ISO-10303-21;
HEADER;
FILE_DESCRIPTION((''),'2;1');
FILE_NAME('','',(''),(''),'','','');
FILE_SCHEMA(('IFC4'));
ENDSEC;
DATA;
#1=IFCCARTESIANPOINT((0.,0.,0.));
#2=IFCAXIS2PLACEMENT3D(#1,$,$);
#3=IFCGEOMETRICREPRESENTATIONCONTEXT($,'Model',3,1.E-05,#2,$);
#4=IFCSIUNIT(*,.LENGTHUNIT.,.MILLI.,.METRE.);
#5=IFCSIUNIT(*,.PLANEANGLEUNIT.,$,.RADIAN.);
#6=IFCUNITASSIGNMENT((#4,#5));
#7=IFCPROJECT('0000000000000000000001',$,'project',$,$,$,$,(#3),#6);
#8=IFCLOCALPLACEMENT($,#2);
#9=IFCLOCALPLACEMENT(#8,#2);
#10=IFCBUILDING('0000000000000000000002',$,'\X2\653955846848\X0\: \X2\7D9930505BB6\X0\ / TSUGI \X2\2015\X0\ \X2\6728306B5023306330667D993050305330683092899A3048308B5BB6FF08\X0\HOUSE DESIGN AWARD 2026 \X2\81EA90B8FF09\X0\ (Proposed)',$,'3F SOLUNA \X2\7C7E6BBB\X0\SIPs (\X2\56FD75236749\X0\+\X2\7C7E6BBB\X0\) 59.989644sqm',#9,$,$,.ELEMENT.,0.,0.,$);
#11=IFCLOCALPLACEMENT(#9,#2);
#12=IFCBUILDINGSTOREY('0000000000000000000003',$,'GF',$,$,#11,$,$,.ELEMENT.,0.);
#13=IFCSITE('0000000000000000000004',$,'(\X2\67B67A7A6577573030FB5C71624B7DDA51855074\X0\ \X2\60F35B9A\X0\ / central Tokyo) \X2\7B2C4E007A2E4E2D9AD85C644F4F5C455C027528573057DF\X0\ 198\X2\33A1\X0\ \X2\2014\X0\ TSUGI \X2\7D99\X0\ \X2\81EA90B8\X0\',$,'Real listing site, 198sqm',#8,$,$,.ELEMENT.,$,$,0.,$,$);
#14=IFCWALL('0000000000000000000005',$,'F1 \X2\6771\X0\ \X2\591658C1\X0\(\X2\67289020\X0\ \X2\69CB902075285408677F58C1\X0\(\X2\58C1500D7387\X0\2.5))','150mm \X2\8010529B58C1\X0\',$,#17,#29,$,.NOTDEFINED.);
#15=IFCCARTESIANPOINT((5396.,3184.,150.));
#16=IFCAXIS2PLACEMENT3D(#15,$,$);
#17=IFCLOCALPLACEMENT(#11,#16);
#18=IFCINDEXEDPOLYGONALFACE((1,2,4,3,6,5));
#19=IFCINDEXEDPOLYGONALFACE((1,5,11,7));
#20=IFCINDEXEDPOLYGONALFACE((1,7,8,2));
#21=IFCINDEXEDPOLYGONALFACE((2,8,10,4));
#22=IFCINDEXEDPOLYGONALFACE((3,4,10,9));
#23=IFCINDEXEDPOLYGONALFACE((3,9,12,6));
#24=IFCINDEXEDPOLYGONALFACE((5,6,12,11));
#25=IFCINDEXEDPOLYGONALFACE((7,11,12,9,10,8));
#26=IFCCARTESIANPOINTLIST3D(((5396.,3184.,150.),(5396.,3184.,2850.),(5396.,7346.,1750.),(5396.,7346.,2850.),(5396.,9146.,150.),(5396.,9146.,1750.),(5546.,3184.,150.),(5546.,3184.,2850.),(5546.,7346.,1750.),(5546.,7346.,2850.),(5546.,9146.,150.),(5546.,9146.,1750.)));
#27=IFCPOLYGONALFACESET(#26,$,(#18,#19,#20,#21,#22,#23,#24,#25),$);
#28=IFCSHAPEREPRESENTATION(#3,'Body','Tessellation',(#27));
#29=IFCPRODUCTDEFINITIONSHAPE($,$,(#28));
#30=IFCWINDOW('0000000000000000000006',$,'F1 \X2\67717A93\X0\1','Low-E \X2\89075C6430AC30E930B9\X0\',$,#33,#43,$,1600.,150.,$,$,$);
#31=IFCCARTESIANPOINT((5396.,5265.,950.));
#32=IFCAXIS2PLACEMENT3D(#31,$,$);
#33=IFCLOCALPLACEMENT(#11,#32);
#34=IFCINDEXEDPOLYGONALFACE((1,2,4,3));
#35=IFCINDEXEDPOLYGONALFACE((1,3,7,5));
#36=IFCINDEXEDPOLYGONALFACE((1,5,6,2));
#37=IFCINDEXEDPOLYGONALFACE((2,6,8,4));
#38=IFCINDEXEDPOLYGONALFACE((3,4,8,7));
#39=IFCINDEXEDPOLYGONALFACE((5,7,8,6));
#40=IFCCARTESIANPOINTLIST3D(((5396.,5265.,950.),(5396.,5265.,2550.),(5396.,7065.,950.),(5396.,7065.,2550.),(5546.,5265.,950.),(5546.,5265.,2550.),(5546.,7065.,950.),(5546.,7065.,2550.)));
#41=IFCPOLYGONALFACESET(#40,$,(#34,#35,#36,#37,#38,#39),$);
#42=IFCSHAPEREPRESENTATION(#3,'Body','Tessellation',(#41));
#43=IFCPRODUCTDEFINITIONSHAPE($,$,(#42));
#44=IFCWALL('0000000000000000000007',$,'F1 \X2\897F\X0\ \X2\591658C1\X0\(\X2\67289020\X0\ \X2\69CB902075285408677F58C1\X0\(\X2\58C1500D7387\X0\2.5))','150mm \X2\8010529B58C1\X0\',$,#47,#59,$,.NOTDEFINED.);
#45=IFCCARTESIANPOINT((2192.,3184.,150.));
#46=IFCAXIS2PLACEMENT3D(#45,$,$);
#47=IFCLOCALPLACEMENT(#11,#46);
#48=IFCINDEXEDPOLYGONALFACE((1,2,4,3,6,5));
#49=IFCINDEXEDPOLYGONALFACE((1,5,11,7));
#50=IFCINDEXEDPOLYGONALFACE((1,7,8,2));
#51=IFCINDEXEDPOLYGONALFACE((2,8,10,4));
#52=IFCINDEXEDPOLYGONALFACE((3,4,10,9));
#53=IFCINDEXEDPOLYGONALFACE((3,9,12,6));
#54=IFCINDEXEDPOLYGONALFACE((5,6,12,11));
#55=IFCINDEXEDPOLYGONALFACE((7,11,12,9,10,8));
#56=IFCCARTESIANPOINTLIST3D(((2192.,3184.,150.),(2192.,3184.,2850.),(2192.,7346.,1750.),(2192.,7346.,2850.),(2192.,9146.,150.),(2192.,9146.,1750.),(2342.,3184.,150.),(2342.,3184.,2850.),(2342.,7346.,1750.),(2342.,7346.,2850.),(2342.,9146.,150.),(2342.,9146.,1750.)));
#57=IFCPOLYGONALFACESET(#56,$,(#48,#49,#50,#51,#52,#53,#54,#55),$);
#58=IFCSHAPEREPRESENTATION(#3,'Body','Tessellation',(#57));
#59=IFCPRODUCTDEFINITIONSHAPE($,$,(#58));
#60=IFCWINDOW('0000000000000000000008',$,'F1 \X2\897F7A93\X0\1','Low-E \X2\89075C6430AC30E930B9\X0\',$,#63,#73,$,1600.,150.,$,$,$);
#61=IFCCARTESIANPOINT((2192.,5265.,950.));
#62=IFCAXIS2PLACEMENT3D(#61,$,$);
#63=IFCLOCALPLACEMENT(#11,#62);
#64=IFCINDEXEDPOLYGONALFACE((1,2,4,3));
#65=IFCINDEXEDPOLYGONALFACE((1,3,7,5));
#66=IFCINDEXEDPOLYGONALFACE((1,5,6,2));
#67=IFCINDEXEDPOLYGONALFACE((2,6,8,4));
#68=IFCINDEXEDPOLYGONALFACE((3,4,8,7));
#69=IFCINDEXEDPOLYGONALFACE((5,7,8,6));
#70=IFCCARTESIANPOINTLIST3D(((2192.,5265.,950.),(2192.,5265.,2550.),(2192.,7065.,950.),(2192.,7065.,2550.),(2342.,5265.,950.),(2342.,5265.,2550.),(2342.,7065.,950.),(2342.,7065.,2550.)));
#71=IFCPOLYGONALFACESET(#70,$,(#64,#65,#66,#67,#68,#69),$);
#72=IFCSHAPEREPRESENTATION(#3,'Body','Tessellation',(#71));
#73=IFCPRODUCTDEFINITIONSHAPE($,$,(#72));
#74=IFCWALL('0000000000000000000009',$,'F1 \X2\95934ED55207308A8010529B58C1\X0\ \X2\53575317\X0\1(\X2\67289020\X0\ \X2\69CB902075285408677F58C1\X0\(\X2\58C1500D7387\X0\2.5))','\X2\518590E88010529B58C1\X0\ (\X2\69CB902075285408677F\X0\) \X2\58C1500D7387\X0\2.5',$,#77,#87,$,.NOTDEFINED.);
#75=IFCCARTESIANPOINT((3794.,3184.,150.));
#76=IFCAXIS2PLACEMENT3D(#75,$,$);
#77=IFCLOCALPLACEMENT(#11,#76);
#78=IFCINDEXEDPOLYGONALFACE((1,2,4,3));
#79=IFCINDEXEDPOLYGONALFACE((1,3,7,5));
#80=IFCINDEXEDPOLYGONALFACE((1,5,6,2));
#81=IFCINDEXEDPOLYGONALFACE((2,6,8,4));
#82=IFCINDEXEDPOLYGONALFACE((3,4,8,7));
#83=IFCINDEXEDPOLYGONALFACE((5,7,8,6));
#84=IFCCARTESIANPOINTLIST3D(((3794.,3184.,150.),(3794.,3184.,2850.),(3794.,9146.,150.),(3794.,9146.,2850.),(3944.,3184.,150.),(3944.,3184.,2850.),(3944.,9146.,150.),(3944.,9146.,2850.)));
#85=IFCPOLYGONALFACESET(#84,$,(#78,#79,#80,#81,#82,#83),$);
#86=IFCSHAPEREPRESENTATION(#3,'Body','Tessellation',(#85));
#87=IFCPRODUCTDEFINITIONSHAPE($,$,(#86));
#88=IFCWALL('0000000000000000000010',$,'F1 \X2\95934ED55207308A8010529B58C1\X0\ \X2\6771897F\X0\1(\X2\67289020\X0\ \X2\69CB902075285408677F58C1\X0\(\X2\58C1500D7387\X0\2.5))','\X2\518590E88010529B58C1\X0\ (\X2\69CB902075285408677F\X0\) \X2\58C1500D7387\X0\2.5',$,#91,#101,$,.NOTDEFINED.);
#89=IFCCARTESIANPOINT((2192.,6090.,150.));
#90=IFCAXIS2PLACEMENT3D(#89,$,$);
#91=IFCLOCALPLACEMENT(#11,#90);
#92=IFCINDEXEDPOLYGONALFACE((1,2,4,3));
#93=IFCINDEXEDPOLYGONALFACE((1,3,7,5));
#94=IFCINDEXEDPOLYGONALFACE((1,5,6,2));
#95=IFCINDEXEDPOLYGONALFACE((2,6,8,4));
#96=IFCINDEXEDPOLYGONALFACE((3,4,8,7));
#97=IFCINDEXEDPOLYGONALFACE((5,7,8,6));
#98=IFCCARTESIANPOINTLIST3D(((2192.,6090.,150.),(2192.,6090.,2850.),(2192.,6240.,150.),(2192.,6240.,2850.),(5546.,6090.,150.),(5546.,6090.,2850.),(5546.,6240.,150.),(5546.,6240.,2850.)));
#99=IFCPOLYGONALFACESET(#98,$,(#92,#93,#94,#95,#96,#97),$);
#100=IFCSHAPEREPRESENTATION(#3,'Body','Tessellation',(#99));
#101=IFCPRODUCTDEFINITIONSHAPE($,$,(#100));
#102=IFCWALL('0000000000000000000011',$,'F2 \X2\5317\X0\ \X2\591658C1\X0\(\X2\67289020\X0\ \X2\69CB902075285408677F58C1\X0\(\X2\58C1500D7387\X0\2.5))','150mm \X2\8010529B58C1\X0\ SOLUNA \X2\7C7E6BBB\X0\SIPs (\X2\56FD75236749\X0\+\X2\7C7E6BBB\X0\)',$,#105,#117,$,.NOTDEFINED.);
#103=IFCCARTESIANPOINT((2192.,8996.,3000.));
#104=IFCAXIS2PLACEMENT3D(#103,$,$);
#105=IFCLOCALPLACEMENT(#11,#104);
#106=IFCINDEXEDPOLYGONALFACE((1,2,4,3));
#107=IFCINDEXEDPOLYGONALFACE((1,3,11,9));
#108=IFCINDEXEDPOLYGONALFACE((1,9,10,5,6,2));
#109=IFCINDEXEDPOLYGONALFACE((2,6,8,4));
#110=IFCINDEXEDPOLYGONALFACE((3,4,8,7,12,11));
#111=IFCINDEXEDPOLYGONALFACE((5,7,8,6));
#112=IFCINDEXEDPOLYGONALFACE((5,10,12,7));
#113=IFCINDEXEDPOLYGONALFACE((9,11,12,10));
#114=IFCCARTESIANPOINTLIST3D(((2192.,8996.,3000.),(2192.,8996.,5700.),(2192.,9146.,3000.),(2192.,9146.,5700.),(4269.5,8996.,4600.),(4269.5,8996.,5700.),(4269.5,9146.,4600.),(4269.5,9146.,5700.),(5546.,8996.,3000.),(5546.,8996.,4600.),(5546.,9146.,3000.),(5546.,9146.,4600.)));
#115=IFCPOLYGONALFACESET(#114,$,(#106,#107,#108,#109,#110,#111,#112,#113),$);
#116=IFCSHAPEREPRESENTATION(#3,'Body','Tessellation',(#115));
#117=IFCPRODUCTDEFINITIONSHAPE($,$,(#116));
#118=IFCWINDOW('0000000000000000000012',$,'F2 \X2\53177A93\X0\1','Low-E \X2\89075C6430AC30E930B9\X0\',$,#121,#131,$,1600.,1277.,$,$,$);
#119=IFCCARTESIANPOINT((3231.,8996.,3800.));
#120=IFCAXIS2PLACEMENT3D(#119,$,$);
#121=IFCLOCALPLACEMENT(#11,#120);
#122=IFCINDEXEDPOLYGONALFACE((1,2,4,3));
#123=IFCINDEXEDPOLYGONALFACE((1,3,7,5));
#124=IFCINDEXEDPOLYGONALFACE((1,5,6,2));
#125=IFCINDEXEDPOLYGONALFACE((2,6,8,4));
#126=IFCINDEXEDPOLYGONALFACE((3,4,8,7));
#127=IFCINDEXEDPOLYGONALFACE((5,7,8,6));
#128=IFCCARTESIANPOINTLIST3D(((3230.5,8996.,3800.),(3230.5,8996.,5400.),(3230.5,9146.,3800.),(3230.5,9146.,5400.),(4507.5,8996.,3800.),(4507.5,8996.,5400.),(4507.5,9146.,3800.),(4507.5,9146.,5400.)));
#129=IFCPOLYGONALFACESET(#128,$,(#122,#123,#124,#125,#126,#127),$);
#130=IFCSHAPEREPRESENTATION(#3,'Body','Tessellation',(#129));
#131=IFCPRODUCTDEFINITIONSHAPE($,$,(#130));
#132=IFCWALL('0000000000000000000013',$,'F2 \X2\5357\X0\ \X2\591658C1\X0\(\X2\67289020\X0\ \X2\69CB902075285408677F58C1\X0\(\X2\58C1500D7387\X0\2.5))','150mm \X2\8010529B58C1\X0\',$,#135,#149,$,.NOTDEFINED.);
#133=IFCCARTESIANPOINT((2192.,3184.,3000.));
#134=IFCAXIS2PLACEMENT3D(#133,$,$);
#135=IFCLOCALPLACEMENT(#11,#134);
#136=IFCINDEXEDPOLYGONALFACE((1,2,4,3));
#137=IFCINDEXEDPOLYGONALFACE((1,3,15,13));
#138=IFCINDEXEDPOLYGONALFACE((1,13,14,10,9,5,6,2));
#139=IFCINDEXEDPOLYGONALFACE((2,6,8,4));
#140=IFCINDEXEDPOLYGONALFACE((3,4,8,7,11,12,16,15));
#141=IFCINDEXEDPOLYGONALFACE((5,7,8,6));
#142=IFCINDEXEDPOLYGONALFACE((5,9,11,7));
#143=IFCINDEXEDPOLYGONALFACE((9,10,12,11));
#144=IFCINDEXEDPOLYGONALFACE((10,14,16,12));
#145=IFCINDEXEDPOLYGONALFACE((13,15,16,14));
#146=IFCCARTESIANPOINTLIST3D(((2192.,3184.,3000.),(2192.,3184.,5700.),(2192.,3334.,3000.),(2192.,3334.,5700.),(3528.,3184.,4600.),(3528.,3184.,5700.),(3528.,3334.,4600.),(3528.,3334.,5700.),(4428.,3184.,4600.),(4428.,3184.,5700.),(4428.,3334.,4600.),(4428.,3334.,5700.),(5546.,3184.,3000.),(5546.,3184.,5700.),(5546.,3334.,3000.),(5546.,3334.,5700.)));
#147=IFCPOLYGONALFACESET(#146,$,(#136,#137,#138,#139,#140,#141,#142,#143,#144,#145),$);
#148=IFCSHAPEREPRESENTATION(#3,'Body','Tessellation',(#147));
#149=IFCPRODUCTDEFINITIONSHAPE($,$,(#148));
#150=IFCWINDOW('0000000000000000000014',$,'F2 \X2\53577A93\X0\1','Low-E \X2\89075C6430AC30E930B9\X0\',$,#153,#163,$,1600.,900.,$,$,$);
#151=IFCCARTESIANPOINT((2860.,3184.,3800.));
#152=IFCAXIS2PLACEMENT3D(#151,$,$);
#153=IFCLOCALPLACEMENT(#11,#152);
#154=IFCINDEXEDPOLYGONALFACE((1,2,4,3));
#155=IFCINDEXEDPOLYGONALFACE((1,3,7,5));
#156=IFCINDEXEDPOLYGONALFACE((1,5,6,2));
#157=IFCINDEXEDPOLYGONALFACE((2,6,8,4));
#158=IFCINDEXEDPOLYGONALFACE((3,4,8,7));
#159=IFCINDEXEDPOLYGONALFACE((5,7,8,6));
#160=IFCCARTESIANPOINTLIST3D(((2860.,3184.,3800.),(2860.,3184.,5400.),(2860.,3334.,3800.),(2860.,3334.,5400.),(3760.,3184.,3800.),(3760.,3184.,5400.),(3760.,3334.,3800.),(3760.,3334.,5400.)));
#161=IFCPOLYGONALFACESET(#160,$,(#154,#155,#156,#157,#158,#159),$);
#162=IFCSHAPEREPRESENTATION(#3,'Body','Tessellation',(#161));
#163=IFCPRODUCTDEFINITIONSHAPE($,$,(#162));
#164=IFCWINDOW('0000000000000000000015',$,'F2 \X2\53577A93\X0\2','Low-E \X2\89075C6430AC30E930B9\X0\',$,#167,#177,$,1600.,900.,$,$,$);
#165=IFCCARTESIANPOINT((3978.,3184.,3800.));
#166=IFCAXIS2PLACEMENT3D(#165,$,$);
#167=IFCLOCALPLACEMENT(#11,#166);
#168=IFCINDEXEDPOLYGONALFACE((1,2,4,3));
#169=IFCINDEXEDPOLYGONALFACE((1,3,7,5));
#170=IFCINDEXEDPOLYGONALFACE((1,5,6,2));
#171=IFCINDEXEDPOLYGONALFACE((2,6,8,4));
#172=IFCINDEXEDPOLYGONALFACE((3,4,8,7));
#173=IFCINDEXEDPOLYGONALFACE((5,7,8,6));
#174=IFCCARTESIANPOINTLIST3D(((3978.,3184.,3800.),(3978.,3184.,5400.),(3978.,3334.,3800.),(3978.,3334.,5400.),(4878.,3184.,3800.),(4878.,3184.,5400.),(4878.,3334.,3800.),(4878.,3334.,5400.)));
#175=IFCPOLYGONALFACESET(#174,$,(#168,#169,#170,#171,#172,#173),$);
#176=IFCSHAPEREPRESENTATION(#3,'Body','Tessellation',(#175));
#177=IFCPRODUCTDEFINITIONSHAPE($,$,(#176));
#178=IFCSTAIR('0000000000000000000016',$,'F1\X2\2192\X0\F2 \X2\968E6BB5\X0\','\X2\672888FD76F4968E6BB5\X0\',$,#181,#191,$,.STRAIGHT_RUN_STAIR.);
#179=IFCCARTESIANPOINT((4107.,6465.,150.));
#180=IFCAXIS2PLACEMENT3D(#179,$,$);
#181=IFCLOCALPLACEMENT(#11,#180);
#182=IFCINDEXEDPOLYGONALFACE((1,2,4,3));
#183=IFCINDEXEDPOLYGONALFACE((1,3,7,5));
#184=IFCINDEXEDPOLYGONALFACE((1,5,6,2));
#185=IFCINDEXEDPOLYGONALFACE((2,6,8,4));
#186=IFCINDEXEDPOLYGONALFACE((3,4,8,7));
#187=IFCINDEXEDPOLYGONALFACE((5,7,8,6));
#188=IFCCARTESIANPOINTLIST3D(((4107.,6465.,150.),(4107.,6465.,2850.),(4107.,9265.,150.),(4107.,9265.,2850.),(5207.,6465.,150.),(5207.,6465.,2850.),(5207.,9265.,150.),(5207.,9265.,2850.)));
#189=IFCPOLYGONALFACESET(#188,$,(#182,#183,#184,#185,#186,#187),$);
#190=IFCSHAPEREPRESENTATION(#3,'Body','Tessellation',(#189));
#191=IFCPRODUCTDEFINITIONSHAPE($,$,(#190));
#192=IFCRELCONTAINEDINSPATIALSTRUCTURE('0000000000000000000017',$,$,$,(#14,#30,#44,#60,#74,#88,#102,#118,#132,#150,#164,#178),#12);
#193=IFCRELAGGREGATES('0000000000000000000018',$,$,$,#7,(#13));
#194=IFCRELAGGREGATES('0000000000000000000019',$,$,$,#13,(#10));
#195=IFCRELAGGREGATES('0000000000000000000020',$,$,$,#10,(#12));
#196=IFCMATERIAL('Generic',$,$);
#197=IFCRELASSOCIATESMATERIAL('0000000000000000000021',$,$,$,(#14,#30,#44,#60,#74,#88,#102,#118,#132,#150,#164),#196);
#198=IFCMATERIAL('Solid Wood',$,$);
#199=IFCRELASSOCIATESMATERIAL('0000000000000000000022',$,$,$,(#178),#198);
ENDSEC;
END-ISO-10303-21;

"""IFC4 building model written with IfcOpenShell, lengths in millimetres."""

from ifc_helpers import new_model, si_unit, frame, frame_2d, origin, place, context, project, spatial, rectangle, extrude, material, element, fill, save


model = new_model("IFC4")

# Units and contexts
model_context = context("Model", 3, precision=1e-05, world=origin())
ifc_project = project(units=[si_unit("LENGTHUNIT", "METRE", prefix="MILLI"), si_unit("PLANEANGLEUNIT", "RADIAN")], contexts=[model_context])

# Site, building, storey
site_placement = place(None, origin())
site = spatial("IfcSite", under=ifc_project, at=site_placement, Name="(架空敷地・山手線内側 想定 / central Tokyo) 第一種中高層住居専用地域 198㎡ — TSUGI 継 自邸", ObjectType="Real listing site, 198sqm", CompositionType="ELEMENT", RefElevation=0.0)
building_placement = place(site_placement, origin())
building = spatial("IfcBuilding", under=site, at=building_placement, Name="改善案: 継ぐ家 / TSUGI ― 木に倣って継ぐことを覚える家（HOUSE DESIGN AWARD 2026 自邸） (Proposed)", ObjectType="3F SOLUNA 籾殻SIPs (国産杉+籾殻) 59.989644sqm", CompositionType="ELEMENT", ElevationOfRefHeight=0.0, ElevationOfTerrain=0.0)
storey_placement = place(building_placement, origin())
storey = spatial("IfcBuildingStorey", under=building, at=storey_placement, Name="GF", CompositionType="ELEMENT", Elevation=0.0)

# Shared definitions
ifc_material_1 = material(Name="Generic")

# Shared definitions
ifc_material_2 = material(Name="Solid Wood")

# Walls, openings, windows
wall_1_placement = place(storey_placement, frame((5396.0, 3184.0, 150.0)))
wall_1 = element("IfcWall", 1, at=wall_1_placement, inside=storey, material=ifc_material_1, Name="F1 東 外壁(木造 構造用合板壁(壁倍率2.5))", Description="150mm 耐力壁", PredefinedType="NOTDEFINED", context=model_context, shape_type="SweptSolid", body=[
    extrude(rectangle(XDim=150.0, YDim=5962.0, at=frame_2d((75.0, 2981.0))), frame((5396.0, 3184.0, 150.0)), (0.0, 0.0, 1.0), 2700.0),
])
opening_1_placement = place(storey_placement, frame((5396.0, 5265.0, 950.0)))
opening_1 = element("IfcOpeningElement", 2, at=opening_1_placement, cuts=wall_1, PredefinedType="NOTDEFINED", context=model_context, shape_type="SweptSolid", body=[
    extrude(rectangle(XDim=150.0, YDim=1800.0, at=frame_2d((75.0, 900.0))), frame((5396.0, 5265.0, 950.0)), (0.0, 0.0, 1.0), 1600.0),
])
window_1_placement = place(storey_placement, frame((5396.0, 5265.0, 950.0)))
window_1 = element("IfcWindow", 3, at=window_1_placement, inside=storey, material=ifc_material_1, Name="F1 東窓1", Description="Low-E 複層ガラス", OverallHeight=1600.0, OverallWidth=150.0, context=model_context, shape_type="SweptSolid", body=[
    extrude(rectangle(XDim=150.0, YDim=1800.0, at=frame_2d((75.0, 900.0))), frame((5396.0, 5265.0, 950.0)), (0.0, 0.0, 1.0), 1600.0),
])
fill(opening_1, window_1)
wall_2_placement = place(storey_placement, frame((2192.0, 3184.0, 150.0)))
wall_2 = element("IfcWall", 4, at=wall_2_placement, inside=storey, material=ifc_material_1, Name="F1 西 外壁(木造 構造用合板壁(壁倍率2.5))", Description="150mm 耐力壁", PredefinedType="NOTDEFINED", context=model_context, shape_type="SweptSolid", body=[
    extrude(rectangle(XDim=150.0, YDim=5962.0, at=frame_2d((75.0, 2981.0))), frame((2192.0, 3184.0, 150.0)), (0.0, 0.0, 1.0), 2700.0),
])
opening_2_placement = place(storey_placement, frame((2192.0, 5265.0, 950.0)))
opening_2 = element("IfcOpeningElement", 5, at=opening_2_placement, cuts=wall_2, PredefinedType="NOTDEFINED", context=model_context, shape_type="SweptSolid", body=[
    extrude(rectangle(XDim=150.0, YDim=1800.0, at=frame_2d((75.0, 900.0))), frame((2192.0, 5265.0, 950.0)), (0.0, 0.0, 1.0), 1600.0),
])
window_2_placement = place(storey_placement, frame((2192.0, 5265.0, 950.0)))
window_2 = element("IfcWindow", 6, at=window_2_placement, inside=storey, material=ifc_material_1, Name="F1 西窓1", Description="Low-E 複層ガラス", OverallHeight=1600.0, OverallWidth=150.0, context=model_context, shape_type="SweptSolid", body=[
    extrude(rectangle(XDim=150.0, YDim=1800.0, at=frame_2d((75.0, 900.0))), frame((2192.0, 5265.0, 950.0)), (0.0, 0.0, 1.0), 1600.0),
])
fill(opening_2, window_2)

# Walls
wall_3_placement = place(storey_placement, frame((3794.0, 3184.0, 150.0)))
element("IfcWall", 7, at=wall_3_placement, inside=storey, material=ifc_material_1, Name="F1 間仕切り耐力壁 南北1(木造 構造用合板壁(壁倍率2.5))", Description="内部耐力壁 (構造用合板) 壁倍率2.5", PredefinedType="NOTDEFINED", context=model_context, shape_type="SweptSolid", body=[
    extrude(rectangle(XDim=150.0, YDim=5962.0, at=frame_2d((75.0, 2981.0))), frame((3794.0, 3184.0, 150.0)), (0.0, 0.0, 1.0), 2700.0),
])
wall_4_placement = place(storey_placement, frame((2192.0, 6090.0, 150.0)))
element("IfcWall", 8, at=wall_4_placement, inside=storey, material=ifc_material_1, Name="F1 間仕切り耐力壁 東西1(木造 構造用合板壁(壁倍率2.5))", Description="内部耐力壁 (構造用合板) 壁倍率2.5", PredefinedType="NOTDEFINED", context=model_context, shape_type="SweptSolid", body=[
    extrude(rectangle(XDim=3354.0, YDim=150.0, at=frame_2d((1677.0, 75.0))), frame((2192.0, 6090.0, 150.0)), (0.0, 0.0, 1.0), 2700.0),
])

# Wall, opening, window
wall_5_placement = place(storey_placement, frame((2192.0, 8996.0, 3000.0)))
wall_5 = element("IfcWall", 9, at=wall_5_placement, inside=storey, material=ifc_material_1, Name="F2 北 外壁(木造 構造用合板壁(壁倍率2.5))", Description="150mm 耐力壁 SOLUNA 籾殻SIPs (国産杉+籾殻)", PredefinedType="NOTDEFINED", context=model_context, shape_type="SweptSolid", body=[
    extrude(rectangle(XDim=3354.0, YDim=150.0, at=frame_2d((1677.0, 75.0))), frame((2192.0, 8996.0, 3000.0)), (0.0, 0.0, 1.0), 2700.0),
])
opening_3_placement = place(storey_placement, frame((3231.0, 8996.0, 3800.0)))
opening_3 = element("IfcOpeningElement", 10, at=opening_3_placement, cuts=wall_5, PredefinedType="NOTDEFINED", context=model_context, shape_type="SweptSolid", body=[
    extrude(rectangle(XDim=1277.0, YDim=150.0, at=frame_2d((638.0, 75.0))), frame((3231.0, 8996.0, 3800.0)), (0.0, 0.0, 1.0), 1600.0),
])
window_3_placement = place(storey_placement, frame((3231.0, 8996.0, 3800.0)))
window_3 = element("IfcWindow", 11, at=window_3_placement, inside=storey, material=ifc_material_1, Name="F2 北窓1", Description="Low-E 複層ガラス", OverallHeight=1600.0, OverallWidth=1277.0, context=model_context, shape_type="SweptSolid", body=[
    extrude(rectangle(XDim=1277.0, YDim=150.0, at=frame_2d((638.0, 75.0))), frame((3231.0, 8996.0, 3800.0)), (0.0, 0.0, 1.0), 1600.0),
])
fill(opening_3, window_3)

# Wall, openings, windows
wall_6_placement = place(storey_placement, frame((2192.0, 3184.0, 3000.0)))
wall_6 = element("IfcWall", 12, at=wall_6_placement, inside=storey, material=ifc_material_1, Name="F2 南 外壁(木造 構造用合板壁(壁倍率2.5))", Description="150mm 耐力壁", PredefinedType="NOTDEFINED", context=model_context, shape_type="SweptSolid", body=[
    extrude(rectangle(XDim=3354.0, YDim=150.0, at=frame_2d((1677.0, 75.0))), frame((2192.0, 3184.0, 3000.0)), (0.0, 0.0, 1.0), 2700.0),
])
opening_4_placement = place(storey_placement, frame((2860.0, 3184.0, 3800.0)))
opening_4 = element("IfcOpeningElement", 13, at=opening_4_placement, cuts=wall_6, PredefinedType="NOTDEFINED", context=model_context, shape_type="SweptSolid", body=[
    extrude(rectangle(XDim=900.0, YDim=150.0, at=frame_2d((450.0, 75.0))), frame((2860.0, 3184.0, 3800.0)), (0.0, 0.0, 1.0), 1600.0),
])
opening_5_placement = place(storey_placement, frame((3978.0, 3184.0, 3800.0)))
opening_5 = element("IfcOpeningElement", 14, at=opening_5_placement, cuts=wall_6, PredefinedType="NOTDEFINED", context=model_context, shape_type="SweptSolid", body=[
    extrude(rectangle(XDim=900.0, YDim=150.0, at=frame_2d((450.0, 75.0))), frame((3978.0, 3184.0, 3800.0)), (0.0, 0.0, 1.0), 1600.0),
])
window_4_placement = place(storey_placement, frame((2860.0, 3184.0, 3800.0)))
window_4 = element("IfcWindow", 15, at=window_4_placement, inside=storey, material=ifc_material_1, Name="F2 南窓1", Description="Low-E 複層ガラス", OverallHeight=1600.0, OverallWidth=900.0, context=model_context, shape_type="SweptSolid", body=[
    extrude(rectangle(XDim=900.0, YDim=150.0, at=frame_2d((450.0, 75.0))), frame((2860.0, 3184.0, 3800.0)), (0.0, 0.0, 1.0), 1600.0),
])
fill(opening_4, window_4)
window_5_placement = place(storey_placement, frame((3978.0, 3184.0, 3800.0)))
window_5 = element("IfcWindow", 16, at=window_5_placement, inside=storey, material=ifc_material_1, Name="F2 南窓2", Description="Low-E 複層ガラス", OverallHeight=1600.0, OverallWidth=900.0, context=model_context, shape_type="SweptSolid", body=[
    extrude(rectangle(XDim=900.0, YDim=150.0, at=frame_2d((450.0, 75.0))), frame((3978.0, 3184.0, 3800.0)), (0.0, 0.0, 1.0), 1600.0),
])
fill(opening_5, window_5)

# Stair
stair_placement = place(storey_placement, frame((4107.0, 6465.0, 150.0)))
element("IfcStair", 17, at=stair_placement, inside=storey, material=ifc_material_2, Name="F1→F2 階段", Description="木製直階段", PredefinedType="STRAIGHT_RUN_STAIR", context=model_context, shape_type="SweptSolid", body=[
    extrude(rectangle(XDim=1100.0, YDim=2800.0, at=frame_2d((550.0, 1400.0))), frame((4107.0, 6465.0, 150.0)), (0.0, 0.0, 1.0), 2700.0),
])

save(model, "model.ifc")
